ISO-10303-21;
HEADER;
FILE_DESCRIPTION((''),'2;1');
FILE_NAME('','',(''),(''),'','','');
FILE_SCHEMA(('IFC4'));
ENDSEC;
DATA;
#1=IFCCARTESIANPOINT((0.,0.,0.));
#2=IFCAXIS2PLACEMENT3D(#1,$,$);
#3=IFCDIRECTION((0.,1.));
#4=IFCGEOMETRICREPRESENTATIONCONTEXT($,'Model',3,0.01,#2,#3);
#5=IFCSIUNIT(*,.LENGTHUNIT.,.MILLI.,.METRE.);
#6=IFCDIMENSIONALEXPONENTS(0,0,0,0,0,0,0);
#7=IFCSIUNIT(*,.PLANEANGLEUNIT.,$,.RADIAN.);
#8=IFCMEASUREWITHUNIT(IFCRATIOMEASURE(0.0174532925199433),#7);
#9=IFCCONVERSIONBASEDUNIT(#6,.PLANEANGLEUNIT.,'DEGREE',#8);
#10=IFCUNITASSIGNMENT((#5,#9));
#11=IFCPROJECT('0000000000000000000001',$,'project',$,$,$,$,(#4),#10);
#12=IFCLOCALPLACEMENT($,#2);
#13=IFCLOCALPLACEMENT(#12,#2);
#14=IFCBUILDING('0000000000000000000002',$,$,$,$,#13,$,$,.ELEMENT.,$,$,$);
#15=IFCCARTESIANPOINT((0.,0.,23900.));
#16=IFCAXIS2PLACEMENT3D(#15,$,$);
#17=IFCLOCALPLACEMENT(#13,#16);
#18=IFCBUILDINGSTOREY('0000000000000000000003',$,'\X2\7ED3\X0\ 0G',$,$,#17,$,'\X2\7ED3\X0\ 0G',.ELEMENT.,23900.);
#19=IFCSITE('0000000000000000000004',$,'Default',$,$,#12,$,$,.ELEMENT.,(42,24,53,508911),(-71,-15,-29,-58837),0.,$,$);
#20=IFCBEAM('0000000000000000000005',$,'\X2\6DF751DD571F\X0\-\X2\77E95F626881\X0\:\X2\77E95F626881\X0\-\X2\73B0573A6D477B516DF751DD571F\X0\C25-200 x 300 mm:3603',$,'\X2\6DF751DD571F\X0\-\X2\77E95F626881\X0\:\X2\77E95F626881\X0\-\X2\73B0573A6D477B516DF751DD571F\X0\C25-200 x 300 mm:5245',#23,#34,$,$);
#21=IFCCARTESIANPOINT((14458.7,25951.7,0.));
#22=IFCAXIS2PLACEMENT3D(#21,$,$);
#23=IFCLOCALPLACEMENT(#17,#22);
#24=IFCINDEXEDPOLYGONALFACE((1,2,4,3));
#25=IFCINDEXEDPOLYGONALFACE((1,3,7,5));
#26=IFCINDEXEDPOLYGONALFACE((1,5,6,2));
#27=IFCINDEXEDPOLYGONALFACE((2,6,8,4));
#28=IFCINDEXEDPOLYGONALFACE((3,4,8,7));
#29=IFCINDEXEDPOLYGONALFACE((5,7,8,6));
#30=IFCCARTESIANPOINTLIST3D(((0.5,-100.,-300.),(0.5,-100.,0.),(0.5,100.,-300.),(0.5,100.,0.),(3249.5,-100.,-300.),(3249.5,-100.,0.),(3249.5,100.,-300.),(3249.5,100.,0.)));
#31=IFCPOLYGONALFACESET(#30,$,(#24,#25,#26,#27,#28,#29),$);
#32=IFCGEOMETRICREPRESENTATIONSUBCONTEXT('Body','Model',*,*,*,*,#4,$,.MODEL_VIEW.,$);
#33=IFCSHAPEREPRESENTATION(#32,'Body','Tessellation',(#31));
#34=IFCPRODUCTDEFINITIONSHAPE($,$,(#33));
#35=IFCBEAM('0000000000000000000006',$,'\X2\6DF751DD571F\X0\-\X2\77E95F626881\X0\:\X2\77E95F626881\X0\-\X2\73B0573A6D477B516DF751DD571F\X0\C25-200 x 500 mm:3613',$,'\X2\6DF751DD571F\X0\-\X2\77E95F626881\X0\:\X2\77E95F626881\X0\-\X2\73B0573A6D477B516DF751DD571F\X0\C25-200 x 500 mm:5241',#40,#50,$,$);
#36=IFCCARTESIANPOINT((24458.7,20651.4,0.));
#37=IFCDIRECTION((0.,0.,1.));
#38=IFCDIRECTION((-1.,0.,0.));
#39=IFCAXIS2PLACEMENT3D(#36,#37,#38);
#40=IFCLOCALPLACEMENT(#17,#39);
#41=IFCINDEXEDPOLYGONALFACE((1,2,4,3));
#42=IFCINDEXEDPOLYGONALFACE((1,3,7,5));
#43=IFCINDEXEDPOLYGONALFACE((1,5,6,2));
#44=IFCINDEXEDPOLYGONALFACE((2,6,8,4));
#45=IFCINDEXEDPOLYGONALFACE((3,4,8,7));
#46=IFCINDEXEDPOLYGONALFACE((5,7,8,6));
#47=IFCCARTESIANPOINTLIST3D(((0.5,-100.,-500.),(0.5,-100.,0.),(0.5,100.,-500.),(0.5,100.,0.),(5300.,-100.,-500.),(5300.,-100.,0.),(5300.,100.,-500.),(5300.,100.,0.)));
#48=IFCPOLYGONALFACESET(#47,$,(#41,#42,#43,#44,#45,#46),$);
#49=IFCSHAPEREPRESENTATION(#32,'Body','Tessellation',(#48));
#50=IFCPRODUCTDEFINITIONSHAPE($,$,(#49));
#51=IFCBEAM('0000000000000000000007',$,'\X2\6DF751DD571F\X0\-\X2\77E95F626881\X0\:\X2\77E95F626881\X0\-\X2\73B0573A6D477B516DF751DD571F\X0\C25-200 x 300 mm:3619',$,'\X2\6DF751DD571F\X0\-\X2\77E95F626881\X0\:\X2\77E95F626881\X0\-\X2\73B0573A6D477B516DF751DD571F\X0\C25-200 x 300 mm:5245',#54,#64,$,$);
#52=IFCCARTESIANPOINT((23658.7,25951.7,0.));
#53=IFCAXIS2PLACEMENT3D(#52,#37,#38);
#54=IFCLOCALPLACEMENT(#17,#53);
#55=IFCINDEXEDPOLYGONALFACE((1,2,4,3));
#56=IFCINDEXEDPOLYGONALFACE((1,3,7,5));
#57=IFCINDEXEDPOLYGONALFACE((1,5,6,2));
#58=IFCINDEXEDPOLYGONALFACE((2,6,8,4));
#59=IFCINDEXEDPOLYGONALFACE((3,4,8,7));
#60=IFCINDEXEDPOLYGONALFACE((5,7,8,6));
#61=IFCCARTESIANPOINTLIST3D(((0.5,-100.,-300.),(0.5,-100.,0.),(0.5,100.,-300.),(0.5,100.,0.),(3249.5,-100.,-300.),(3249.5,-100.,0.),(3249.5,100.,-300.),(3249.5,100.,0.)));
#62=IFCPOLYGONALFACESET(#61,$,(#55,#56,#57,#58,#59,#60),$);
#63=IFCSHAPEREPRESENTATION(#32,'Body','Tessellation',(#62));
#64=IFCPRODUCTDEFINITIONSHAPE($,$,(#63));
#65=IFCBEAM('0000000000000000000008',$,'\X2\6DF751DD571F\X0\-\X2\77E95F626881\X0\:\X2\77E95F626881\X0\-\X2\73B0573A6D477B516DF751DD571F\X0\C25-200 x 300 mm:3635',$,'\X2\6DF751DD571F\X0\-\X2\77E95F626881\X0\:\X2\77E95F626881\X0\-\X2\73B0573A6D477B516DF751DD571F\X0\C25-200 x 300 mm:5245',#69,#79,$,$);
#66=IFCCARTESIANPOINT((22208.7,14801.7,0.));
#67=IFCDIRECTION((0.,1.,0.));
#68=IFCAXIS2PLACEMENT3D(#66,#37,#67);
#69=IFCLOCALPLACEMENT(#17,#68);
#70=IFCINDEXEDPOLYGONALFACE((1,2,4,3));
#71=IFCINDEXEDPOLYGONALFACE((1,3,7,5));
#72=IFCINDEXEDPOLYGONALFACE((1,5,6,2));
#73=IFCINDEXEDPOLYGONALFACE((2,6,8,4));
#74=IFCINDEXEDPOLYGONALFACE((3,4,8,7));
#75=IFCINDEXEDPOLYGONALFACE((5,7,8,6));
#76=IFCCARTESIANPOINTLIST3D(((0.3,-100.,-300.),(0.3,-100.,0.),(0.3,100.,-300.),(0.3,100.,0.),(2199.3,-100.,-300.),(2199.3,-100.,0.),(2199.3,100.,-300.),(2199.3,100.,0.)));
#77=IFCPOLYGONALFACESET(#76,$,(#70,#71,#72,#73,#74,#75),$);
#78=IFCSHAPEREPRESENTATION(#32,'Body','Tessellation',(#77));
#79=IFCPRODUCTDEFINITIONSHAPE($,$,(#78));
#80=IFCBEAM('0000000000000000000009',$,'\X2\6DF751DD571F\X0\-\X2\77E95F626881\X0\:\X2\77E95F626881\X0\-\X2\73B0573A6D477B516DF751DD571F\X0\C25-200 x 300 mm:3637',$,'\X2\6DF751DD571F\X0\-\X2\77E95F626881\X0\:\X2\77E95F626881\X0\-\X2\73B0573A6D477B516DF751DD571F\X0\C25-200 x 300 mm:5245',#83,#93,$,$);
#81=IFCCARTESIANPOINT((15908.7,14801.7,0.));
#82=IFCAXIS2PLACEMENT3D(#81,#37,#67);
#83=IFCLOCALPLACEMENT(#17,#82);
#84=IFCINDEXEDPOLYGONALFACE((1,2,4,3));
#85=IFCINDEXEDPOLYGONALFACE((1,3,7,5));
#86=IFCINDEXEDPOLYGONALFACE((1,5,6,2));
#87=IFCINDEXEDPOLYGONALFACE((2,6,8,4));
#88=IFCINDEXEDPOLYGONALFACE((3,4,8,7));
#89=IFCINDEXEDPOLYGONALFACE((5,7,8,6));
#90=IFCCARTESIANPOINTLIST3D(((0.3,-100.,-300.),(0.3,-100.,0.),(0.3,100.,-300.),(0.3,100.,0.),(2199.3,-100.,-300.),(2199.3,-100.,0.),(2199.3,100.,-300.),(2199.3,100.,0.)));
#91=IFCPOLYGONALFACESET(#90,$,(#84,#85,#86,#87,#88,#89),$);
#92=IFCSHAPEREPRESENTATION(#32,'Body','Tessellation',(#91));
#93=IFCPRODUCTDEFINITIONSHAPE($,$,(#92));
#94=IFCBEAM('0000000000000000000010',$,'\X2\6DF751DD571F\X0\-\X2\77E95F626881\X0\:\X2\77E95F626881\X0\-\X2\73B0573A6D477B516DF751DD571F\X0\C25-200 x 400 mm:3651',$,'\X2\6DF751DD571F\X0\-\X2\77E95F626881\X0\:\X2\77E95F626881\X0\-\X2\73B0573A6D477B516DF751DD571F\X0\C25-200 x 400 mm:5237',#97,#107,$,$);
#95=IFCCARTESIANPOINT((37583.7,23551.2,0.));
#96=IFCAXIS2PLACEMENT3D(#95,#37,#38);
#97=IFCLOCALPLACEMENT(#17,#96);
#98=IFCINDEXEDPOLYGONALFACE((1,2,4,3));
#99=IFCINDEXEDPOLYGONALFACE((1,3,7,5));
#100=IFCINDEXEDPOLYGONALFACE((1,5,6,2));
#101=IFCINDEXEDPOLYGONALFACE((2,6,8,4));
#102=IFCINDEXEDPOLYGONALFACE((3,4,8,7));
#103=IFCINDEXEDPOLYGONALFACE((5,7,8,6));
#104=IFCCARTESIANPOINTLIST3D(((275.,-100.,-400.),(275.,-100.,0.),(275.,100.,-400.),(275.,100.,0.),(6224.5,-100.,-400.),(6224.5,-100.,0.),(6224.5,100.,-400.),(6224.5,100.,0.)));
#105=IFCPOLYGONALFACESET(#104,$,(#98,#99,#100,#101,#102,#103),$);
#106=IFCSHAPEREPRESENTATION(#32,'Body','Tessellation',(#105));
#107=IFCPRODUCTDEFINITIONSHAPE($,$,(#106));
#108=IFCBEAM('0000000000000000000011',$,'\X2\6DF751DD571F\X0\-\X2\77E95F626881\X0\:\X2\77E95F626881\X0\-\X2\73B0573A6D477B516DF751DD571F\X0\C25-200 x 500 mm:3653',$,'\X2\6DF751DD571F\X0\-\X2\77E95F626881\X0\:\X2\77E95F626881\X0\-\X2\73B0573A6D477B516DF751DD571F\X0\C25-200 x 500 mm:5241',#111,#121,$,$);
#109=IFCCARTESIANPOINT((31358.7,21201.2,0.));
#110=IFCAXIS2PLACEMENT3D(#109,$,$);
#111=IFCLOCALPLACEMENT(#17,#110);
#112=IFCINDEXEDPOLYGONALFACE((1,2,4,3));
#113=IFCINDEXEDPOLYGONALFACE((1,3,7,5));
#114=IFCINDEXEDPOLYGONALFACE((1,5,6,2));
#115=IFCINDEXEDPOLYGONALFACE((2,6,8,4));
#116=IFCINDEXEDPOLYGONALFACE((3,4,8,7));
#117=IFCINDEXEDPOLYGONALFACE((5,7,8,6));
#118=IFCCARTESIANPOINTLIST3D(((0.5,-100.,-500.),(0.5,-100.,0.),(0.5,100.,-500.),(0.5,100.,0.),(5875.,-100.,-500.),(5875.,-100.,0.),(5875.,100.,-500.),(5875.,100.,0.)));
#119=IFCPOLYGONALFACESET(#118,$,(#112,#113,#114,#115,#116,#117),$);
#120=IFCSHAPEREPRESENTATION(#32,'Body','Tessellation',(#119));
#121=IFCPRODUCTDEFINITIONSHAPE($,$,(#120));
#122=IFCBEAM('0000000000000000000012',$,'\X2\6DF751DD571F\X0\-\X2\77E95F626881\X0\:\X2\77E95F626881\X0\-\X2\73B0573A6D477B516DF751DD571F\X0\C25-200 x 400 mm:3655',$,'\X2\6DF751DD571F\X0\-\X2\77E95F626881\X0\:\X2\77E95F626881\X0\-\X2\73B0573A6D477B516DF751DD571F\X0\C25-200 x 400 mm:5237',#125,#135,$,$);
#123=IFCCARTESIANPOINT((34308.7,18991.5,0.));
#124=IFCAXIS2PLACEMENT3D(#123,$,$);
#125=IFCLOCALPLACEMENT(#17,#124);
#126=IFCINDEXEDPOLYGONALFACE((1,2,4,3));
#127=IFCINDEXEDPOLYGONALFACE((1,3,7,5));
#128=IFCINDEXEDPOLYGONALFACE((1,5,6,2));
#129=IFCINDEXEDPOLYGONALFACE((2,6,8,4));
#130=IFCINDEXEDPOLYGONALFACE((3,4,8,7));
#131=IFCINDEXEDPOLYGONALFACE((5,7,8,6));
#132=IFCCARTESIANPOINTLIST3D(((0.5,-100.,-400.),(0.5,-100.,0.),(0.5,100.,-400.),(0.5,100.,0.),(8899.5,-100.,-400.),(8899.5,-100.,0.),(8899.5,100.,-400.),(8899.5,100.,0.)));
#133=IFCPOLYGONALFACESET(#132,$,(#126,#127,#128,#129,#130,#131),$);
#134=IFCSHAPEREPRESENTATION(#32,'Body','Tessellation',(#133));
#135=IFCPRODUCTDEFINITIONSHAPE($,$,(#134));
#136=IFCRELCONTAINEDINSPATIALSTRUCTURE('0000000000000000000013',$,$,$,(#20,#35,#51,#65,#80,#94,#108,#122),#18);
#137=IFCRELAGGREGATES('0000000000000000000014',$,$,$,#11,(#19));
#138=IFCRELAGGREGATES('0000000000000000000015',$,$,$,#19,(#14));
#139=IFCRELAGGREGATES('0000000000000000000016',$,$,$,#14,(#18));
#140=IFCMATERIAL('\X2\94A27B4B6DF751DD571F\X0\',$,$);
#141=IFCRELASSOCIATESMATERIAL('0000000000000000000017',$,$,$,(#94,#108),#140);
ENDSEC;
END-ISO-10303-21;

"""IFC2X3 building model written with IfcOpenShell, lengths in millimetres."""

from ifc_helpers import new_model, entity, si_unit, converted_unit, direction, frame, frame_2d, origin, origin_2d_with_axis, place, context, subcontext, project, spatial, rectangle, extrude, material, element, save


model = new_model("IFC2X3")

# Units and contexts
model_context = context("Model", 3, precision=0.01, world=origin(), true_north=direction((0.0, 1.0)))
body_context = subcontext(model_context, "Body", "Model", "MODEL_VIEW")
ifc_project = project(units=[si_unit("LENGTHUNIT", "METRE", prefix="MILLI"), converted_unit("PLANEANGLEUNIT", "DEGREE", entity("IfcRatioMeasure", 0.0174532925199433), si_unit("PLANEANGLEUNIT", "RADIAN"), dimensions=[0, 0, 0, 0, 0, 0, 0])], contexts=[model_context])

# Site, building, storey
site_placement = place(None, origin())
site = spatial("IfcSite", under=ifc_project, at=site_placement, Name="Default", CompositionType="ELEMENT", RefLatitude=(42, 24, 53, 508911), RefLongitude=(-71, -15, -29, -58837), RefElevation=0.0)
building_placement = place(site_placement, origin())
building = spatial("IfcBuilding", under=site, at=building_placement, CompositionType="ELEMENT")
storey_placement = place(building_placement, frame((0.0, 0.0, 23900.0)))
storey = spatial("IfcBuildingStorey", under=building, at=storey_placement, Name="结 0G", LongName="结 0G", CompositionType="ELEMENT", Elevation=23900.0)

# Beams
ifc_material = material(Name="钢筋混凝土")
beam_1_placement = place(storey_placement, frame((14458.7, 25951.7, 0.0)))
element("IfcBeam", 1, at=beam_1_placement, inside=storey, Name="混凝土-矩形梁:矩形梁-现场浇筑混凝土C25-200 x 300 mm:3603", ObjectType="混凝土-矩形梁:矩形梁-现场浇筑混凝土C25-200 x 300 mm:5245", context=body_context, shape_type="SweptSolid", body=[
    extrude(rectangle(XDim=300.0, YDim=200.0, at=frame_2d((0.0, 0.0), x_axis=(1.0, 0.0))), frame((0.5, 0.0, -150.0), z_axis=(1.0, 0.0, 0.0), x_axis=(0.0, 0.0, -1.0)), (0.0, 0.0, 1.0), 3249.0),
])
beam_2_placement = place(storey_placement, frame((24458.7, 20651.4, 0.0), z_axis=(0.0, 0.0, 1.0), x_axis=(-1.0, 0.0, 0.0)))
element("IfcBeam", 2, at=beam_2_placement, inside=storey, Name="混凝土-矩形梁:矩形梁-现场浇筑混凝土C25-200 x 500 mm:3613", ObjectType="混凝土-矩形梁:矩形梁-现场浇筑混凝土C25-200 x 500 mm:5241", context=body_context, shape_type="SweptSolid", body=[
    extrude(rectangle(XDim=500.0, YDim=200.0, at=frame_2d((0.0, 0.0), x_axis=(1.0, 0.0))), frame((0.5, 0.0, -250.0), z_axis=(1.0, 0.0, 0.0), x_axis=(0.0, 0.0, -1.0)), (0.0, 0.0, 1.0), 5299.5),
])
beam_3_placement = place(storey_placement, frame((23658.7, 25951.7, 0.0), z_axis=(0.0, 0.0, 1.0), x_axis=(-1.0, 0.0, 0.0)))
element("IfcBeam", 3, at=beam_3_placement, inside=storey, Name="混凝土-矩形梁:矩形梁-现场浇筑混凝土C25-200 x 300 mm:3619", ObjectType="混凝土-矩形梁:矩形梁-现场浇筑混凝土C25-200 x 300 mm:5245", context=body_context, shape_type="SweptSolid", body=[
    extrude(rectangle(XDim=300.0, YDim=200.0, at=frame_2d((0.0, 0.0), x_axis=(1.0, 0.0))), frame((0.5, 0.0, -150.0), z_axis=(1.0, 0.0, 0.0), x_axis=(0.0, 0.0, -1.0)), (0.0, 0.0, 1.0), 3249.0),
])
beam_4_placement = place(storey_placement, frame((22208.7, 14801.7, 0.0), z_axis=(0.0, 0.0, 1.0), x_axis=(0.0, 1.0, 0.0)))
element("IfcBeam", 4, at=beam_4_placement, inside=storey, Name="混凝土-矩形梁:矩形梁-现场浇筑混凝土C25-200 x 300 mm:3635", ObjectType="混凝土-矩形梁:矩形梁-现场浇筑混凝土C25-200 x 300 mm:5245", context=body_context, shape_type="SweptSolid", body=[
    extrude(rectangle(XDim=300.0, YDim=200.0, at=frame_2d((0.0, 0.0), x_axis=(1.0, 0.0))), frame((0.3, 0.0, -150.0), z_axis=(1.0, 0.0, 0.0), x_axis=(0.0, 0.0, -1.0)), (0.0, 0.0, 1.0), 2199.0),
])
beam_5_placement = place(storey_placement, frame((15908.7, 14801.7, 0.0), z_axis=(0.0, 0.0, 1.0), x_axis=(0.0, 1.0, 0.0)))
element("IfcBeam", 5, at=beam_5_placement, inside=storey, Name="混凝土-矩形梁:矩形梁-现场浇筑混凝土C25-200 x 300 mm:3637", ObjectType="混凝土-矩形梁:矩形梁-现场浇筑混凝土C25-200 x 300 mm:5245", context=body_context, shape_type="SweptSolid", body=[
    extrude(rectangle(XDim=300.0, YDim=200.0, at=origin_2d_with_axis()), frame((0.3, 0.0, -150.0), z_axis=(1.0, 0.0, 0.0), x_axis=(0.0, 0.0, -1.0)), (0.0, 0.0, 1.0), 2199.0),
])
beam_6_placement = place(storey_placement, frame((37583.7, 23551.2, 0.0), z_axis=(0.0, 0.0, 1.0), x_axis=(-1.0, 0.0, 0.0)))
element("IfcBeam", 6, at=beam_6_placement, inside=storey, material=ifc_material, Name="混凝土-矩形梁:矩形梁-现场浇筑混凝土C25-200 x 400 mm:3651", ObjectType="混凝土-矩形梁:矩形梁-现场浇筑混凝土C25-200 x 400 mm:5237", context=body_context, shape_type="SweptSolid", body=[
    extrude(rectangle(XDim=400.0, YDim=200.0, at=frame_2d((0.0, 0.0), x_axis=(1.0, 0.0))), frame((275.0, 0.0, -200.0), z_axis=(1.0, 0.0, 0.0), x_axis=(0.0, 0.0, -1.0)), (0.0, 0.0, 1.0), 5949.5),
])
beam_7_placement = place(storey_placement, frame((31358.7, 21201.2, 0.0)))
element("IfcBeam", 7, at=beam_7_placement, inside=storey, material=ifc_material, Name="混凝土-矩形梁:矩形梁-现场浇筑混凝土C25-200 x 500 mm:3653", ObjectType="混凝土-矩形梁:矩形梁-现场浇筑混凝土C25-200 x 500 mm:5241", context=body_context, shape_type="SweptSolid", body=[
    extrude(rectangle(XDim=500.0, YDim=200.0, at=frame_2d((0.0, 0.0), x_axis=(1.0, 0.0))), frame((0.5, 0.0, -250.0), z_axis=(1.0, 0.0, 0.0), x_axis=(0.0, 0.0, -1.0)), (0.0, 0.0, 1.0), 5874.5),
])
beam_8_placement = place(storey_placement, frame((34308.7, 18991.5, 0.0)))
element("IfcBeam", 8, at=beam_8_placement, inside=storey, Name="混凝土-矩形梁:矩形梁-现场浇筑混凝土C25-200 x 400 mm:3655", ObjectType="混凝土-矩形梁:矩形梁-现场浇筑混凝土C25-200 x 400 mm:5237", context=body_context, shape_type="SweptSolid", body=[
    extrude(rectangle(XDim=400.0, YDim=200.0, at=frame_2d((0.0, 0.0), x_axis=(1.0, 0.0))), frame((0.5, 0.0, -200.0), z_axis=(1.0, 0.0, 0.0), x_axis=(0.0, 0.0, -1.0)), (0.0, 0.0, 1.0), 8899.0),
])

save(model, "model.ifc")
